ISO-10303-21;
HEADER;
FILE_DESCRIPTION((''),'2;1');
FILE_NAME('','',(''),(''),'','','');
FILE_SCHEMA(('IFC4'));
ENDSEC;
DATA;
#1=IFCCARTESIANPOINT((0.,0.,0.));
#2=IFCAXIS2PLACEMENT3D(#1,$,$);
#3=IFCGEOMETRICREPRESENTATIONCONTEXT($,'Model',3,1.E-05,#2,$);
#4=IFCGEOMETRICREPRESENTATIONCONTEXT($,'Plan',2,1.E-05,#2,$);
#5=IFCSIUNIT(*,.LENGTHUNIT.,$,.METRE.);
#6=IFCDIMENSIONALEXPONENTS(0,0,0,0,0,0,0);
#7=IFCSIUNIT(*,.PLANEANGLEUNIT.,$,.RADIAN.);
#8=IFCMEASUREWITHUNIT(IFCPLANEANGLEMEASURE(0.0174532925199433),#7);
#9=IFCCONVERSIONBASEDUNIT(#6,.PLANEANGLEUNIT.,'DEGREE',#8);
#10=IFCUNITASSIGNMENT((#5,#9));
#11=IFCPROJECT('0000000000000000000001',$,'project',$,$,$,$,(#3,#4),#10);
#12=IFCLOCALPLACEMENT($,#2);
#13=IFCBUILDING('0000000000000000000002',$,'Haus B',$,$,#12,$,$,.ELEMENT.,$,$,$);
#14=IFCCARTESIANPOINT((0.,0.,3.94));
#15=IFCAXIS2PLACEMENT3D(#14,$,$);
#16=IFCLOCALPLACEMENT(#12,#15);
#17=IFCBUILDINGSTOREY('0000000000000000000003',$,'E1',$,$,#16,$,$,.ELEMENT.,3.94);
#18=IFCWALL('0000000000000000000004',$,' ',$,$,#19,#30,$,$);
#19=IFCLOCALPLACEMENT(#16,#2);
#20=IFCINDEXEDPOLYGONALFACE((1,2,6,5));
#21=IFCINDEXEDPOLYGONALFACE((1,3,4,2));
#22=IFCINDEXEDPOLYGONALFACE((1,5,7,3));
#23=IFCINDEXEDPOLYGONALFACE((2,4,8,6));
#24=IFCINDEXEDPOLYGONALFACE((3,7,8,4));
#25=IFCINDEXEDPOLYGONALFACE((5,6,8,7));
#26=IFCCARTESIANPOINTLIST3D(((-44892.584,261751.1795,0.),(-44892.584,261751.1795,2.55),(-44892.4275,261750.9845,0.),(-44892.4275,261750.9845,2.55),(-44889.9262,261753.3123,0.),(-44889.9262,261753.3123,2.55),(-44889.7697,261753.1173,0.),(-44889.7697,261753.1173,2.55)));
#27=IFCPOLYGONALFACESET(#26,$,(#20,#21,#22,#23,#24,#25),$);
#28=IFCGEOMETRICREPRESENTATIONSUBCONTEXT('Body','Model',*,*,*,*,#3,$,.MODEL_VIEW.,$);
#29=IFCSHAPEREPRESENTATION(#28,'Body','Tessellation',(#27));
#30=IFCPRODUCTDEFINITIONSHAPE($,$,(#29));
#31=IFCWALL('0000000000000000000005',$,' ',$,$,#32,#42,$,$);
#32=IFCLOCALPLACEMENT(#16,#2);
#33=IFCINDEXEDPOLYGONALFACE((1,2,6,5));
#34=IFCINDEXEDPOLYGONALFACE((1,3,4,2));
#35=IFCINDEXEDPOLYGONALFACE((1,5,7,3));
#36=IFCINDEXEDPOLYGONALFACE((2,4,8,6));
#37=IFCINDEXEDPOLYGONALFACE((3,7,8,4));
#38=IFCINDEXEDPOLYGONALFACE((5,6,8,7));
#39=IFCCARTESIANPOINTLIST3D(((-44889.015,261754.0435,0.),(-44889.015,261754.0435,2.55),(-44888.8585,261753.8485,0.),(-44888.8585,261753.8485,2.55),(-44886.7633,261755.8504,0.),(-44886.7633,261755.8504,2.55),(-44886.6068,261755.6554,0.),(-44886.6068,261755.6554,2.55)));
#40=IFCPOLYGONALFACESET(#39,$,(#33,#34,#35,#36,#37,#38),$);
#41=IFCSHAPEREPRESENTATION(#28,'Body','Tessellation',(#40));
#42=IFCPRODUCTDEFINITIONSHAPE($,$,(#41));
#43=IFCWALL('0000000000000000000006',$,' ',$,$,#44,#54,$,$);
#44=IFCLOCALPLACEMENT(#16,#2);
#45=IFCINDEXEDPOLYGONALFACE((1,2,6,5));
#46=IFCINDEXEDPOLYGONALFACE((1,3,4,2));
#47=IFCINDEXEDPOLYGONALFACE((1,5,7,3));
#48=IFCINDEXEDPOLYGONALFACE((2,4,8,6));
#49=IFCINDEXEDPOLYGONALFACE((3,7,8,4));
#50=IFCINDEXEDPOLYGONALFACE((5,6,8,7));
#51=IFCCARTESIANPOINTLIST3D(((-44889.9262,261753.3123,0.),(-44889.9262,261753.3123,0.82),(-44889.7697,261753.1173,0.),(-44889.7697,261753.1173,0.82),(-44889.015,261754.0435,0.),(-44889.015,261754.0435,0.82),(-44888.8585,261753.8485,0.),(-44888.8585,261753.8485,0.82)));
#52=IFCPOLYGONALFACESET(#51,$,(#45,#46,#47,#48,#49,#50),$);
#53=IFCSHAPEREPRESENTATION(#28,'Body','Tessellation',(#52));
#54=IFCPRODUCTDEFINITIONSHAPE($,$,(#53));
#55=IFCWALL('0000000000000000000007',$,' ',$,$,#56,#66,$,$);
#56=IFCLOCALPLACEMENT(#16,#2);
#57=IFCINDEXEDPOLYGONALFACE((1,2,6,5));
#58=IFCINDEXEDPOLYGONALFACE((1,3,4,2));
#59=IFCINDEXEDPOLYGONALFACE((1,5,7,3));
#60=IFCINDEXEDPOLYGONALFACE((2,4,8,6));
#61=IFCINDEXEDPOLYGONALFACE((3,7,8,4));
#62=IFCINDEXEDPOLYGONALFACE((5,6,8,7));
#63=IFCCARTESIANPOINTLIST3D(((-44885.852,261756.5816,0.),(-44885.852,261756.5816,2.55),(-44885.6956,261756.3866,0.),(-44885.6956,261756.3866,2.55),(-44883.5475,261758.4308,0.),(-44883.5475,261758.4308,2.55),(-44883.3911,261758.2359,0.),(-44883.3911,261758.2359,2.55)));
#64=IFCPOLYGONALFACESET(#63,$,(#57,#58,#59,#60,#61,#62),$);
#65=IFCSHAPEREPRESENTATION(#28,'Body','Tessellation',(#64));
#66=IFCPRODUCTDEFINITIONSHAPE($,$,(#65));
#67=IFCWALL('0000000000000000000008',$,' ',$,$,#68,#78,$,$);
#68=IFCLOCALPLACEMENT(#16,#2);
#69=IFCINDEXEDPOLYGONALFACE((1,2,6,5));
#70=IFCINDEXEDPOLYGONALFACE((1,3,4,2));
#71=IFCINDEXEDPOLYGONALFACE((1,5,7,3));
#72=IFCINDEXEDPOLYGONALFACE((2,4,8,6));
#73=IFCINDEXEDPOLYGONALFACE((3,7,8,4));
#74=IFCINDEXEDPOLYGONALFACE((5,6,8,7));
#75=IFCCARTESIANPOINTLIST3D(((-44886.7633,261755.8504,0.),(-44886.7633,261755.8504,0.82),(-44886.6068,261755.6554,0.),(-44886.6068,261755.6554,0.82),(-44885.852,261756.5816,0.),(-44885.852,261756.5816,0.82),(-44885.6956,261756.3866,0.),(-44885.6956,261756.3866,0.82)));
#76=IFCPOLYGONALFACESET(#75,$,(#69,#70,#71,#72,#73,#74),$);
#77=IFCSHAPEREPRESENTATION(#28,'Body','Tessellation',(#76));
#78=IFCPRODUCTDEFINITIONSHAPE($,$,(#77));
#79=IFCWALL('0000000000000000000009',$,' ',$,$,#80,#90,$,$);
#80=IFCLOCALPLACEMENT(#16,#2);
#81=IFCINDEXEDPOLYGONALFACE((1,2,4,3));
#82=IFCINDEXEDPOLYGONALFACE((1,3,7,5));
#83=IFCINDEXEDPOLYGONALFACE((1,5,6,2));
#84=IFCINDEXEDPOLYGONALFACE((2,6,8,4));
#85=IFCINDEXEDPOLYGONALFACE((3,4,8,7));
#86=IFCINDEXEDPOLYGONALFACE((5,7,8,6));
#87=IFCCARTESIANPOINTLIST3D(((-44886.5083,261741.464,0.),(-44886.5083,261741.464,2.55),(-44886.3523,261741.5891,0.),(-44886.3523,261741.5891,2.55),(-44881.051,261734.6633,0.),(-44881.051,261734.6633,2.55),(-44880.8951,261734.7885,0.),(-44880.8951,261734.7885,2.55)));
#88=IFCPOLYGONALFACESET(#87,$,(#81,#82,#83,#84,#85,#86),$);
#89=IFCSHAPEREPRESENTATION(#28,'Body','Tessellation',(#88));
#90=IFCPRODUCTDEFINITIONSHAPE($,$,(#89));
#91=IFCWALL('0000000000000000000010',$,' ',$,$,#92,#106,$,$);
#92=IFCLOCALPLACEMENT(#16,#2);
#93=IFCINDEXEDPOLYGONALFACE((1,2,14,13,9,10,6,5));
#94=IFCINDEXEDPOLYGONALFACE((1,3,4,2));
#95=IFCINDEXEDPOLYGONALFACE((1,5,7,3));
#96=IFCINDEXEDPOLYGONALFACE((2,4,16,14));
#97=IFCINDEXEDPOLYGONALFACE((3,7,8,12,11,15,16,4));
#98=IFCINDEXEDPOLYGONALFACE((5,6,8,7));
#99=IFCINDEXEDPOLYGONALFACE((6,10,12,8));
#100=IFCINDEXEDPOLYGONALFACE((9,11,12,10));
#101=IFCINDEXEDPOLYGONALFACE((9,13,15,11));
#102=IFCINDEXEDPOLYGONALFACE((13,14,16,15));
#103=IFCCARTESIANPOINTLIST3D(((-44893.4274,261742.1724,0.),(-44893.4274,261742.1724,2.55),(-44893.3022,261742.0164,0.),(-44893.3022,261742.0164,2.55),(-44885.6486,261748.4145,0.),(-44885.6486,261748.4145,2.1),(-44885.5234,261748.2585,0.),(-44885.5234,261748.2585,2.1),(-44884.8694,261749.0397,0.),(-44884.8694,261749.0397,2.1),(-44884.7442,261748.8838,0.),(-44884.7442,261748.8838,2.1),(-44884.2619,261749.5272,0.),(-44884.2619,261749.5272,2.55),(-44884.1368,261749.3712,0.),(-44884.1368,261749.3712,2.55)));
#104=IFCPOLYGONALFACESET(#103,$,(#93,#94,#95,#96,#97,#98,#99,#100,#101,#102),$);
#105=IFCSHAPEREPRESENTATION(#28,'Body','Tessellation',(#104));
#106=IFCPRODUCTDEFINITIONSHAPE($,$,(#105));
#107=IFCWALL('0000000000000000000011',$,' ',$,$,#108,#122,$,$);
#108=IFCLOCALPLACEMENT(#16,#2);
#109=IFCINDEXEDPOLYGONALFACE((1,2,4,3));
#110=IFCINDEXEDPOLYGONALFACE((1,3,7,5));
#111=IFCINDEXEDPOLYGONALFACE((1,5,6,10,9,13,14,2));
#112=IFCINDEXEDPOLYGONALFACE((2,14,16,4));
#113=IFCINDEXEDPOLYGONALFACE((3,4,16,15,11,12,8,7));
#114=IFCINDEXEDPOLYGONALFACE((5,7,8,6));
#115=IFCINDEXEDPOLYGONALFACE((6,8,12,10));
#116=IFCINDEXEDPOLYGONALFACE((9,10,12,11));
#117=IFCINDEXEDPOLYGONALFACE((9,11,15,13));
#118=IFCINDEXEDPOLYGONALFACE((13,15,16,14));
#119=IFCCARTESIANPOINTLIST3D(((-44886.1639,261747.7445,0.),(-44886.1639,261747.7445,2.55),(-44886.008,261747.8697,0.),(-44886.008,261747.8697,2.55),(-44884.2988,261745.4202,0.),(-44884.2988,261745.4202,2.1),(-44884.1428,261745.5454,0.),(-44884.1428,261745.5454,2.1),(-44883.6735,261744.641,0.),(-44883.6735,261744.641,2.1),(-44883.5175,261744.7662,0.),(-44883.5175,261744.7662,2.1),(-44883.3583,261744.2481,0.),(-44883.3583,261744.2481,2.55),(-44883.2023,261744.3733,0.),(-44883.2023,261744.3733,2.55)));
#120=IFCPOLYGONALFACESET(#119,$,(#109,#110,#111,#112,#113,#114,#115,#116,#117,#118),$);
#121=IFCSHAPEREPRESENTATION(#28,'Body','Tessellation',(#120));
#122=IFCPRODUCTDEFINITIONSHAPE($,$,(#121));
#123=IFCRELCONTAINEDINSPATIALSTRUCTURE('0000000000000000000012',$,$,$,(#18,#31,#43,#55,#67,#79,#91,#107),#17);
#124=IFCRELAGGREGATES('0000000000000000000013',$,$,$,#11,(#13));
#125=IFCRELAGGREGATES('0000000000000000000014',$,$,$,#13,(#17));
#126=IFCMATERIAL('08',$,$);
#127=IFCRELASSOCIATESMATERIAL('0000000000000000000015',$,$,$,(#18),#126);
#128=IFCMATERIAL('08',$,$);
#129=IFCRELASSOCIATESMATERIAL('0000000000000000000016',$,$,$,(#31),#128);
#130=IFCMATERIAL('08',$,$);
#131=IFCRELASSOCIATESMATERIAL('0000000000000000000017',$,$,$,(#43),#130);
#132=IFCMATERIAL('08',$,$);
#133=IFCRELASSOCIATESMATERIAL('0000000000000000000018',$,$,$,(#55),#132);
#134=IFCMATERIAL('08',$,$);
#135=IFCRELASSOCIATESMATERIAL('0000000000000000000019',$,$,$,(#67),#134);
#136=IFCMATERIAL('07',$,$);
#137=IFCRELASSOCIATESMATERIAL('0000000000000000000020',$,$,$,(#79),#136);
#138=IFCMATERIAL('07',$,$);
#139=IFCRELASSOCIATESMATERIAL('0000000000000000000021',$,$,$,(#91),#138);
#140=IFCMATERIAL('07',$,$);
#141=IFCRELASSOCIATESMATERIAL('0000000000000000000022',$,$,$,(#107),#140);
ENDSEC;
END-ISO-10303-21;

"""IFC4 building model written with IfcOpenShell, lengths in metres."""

from ifc_helpers import new_model, entity, si_unit, converted_unit, frame, frame_2d, origin, origin_with_axes, place, context, subcontext, project, spatial, polyline, rectangle, outline, extrude, material, element, save


model = new_model("IFC4")

# Units and contexts
model_context = context("Model", 3, precision=1e-05, world=origin())
plan_context = context("Plan", 2, precision=1e-05, world=origin())
body_context = subcontext(model_context, "Body", "Model", "MODEL_VIEW")
ifc_project = project(units=[si_unit("LENGTHUNIT", "METRE"), converted_unit("PLANEANGLEUNIT", "DEGREE", entity("IfcPlaneAngleMeasure", 0.0174532925199433), si_unit("PLANEANGLEUNIT", "RADIAN"), dimensions=[0, 0, 0, 0, 0, 0, 0])], contexts=[model_context, plan_context])

# Building, storey
building_placement = place(None, origin())
building = spatial("IfcBuilding", under=ifc_project, at=building_placement, Name="Haus B", CompositionType="ELEMENT")
storey_placement = place(building_placement, frame((0.0, 0.0, 3.94)))
storey = spatial("IfcBuildingStorey", under=building, at=storey_placement, Name="E1", CompositionType="ELEMENT", Elevation=3.94)

# Walls
ifc_material_1 = material(Name="08")
wall_1_placement = place(storey_placement, frame((-44892.4275, 261750.9845, 0.0), z_axis=(0.0, 0.0, 1.0), x_axis=(0.779935, 0.625861, 0.0)))
element("IfcWall", 1, at=wall_1_placement, inside=storey, material=ifc_material_1, Name=" ", context=body_context, shape_type="SweptSolid", body=[
    extrude(rectangle(XDim=3.4077, YDim=0.25, at=frame_2d((1.7039, 0.125), x_axis=(1.0, 0.0))), origin_with_axes(), (0.0, 0.0, 1.0), 2.55),
])
ifc_material_2 = material(Name="08")
wall_2_placement = place(storey_placement, frame((-44888.8585, 261753.8485, 0.0), z_axis=(0.0, 0.0, 1.0), x_axis=(0.779935, 0.625861, 0.0)))
element("IfcWall", 2, at=wall_2_placement, inside=storey, material=ifc_material_2, Name=" ", context=body_context, shape_type="SweptSolid", body=[
    extrude(rectangle(XDim=2.887, YDim=0.25, at=frame_2d((1.4435, 0.125), x_axis=(1.0, 0.0))), origin_with_axes(), (0.0, 0.0, 1.0), 2.55),
])
ifc_material_3 = material(Name="08")
wall_3_placement = place(storey_placement, frame((-44889.7697, 261753.1173, 0.0), z_axis=(0.0, 0.0, 1.0), x_axis=(0.779935, 0.625861, 0.0)))
element("IfcWall", 3, at=wall_3_placement, inside=storey, material=ifc_material_3, Name=" ", context=body_context, shape_type="SweptSolid", body=[
    extrude(rectangle(XDim=1.1684, YDim=0.25, at=frame_2d((0.5842, 0.125), x_axis=(1.0, 0.0))), origin_with_axes(), (0.0, 0.0, 1.0), 0.82),
])
ifc_material_4 = material(Name="08")
wall_4_placement = place(storey_placement, frame((-44885.6956, 261756.3866, 0.0), z_axis=(0.0, 0.0, 1.0), x_axis=(0.779935, 0.625861, 0.0)))
element("IfcWall", 4, at=wall_4_placement, inside=storey, material=ifc_material_4, Name=" ", context=body_context, shape_type="SweptSolid", body=[
    extrude(rectangle(XDim=2.9548, YDim=0.25, at=frame_2d((1.4774, 0.125), x_axis=(1.0, 0.0))), origin_with_axes(), (0.0, 0.0, 1.0), 2.55),
])
ifc_material_5 = material(Name="08")
wall_5_placement = place(storey_placement, frame((-44886.6068, 261755.6554, 0.0), z_axis=(0.0, 0.0, 1.0), x_axis=(0.779935, 0.625861, 0.0)))
element("IfcWall", 5, at=wall_5_placement, inside=storey, material=ifc_material_5, Name=" ", context=body_context, shape_type="SweptSolid", body=[
    extrude(rectangle(XDim=1.1684, YDim=0.25, at=frame_2d((0.5842, 0.125), x_axis=(1.0, 0.0))), origin_with_axes(), (0.0, 0.0, 1.0), 0.82),
])
ifc_material_6 = material(Name="07")
wall_6_placement = place(storey_placement, frame((-44886.5083, 261741.464, 0.0), z_axis=(0.0, 0.0, 1.0), x_axis=(0.625861, -0.779935, 0.0)))
element("IfcWall", 6, at=wall_6_placement, inside=storey, material=ifc_material_6, Name=" ", context=body_context, shape_type="SweptSolid", body=[
    extrude(rectangle(XDim=8.7195, YDim=0.2, at=frame_2d((4.3598, 0.1), x_axis=(1.0, 0.0))), origin_with_axes(), (0.0, 0.0, 1.0), 2.55),
])

# Walls, openings
ifc_material_7 = material(Name="07")
wall_7_placement = place(storey_placement, frame((-44893.3022, 261742.0164, 0.0), z_axis=(0.0, 0.0, 1.0), x_axis=(0.779935, 0.625861, 0.0)))
wall_7 = element("IfcWall", 7, at=wall_7_placement, inside=storey, material=ifc_material_7, Name=" ", context=body_context, shape_type="SweptSolid", body=[
    extrude(rectangle(XDim=11.7515, YDim=0.2, at=frame_2d((5.8758, 0.1), x_axis=(1.0, 0.0))), origin_with_axes(), (0.0, 0.0, 1.0), 2.55),
])
opening_1_placement = place(wall_7_placement, frame((9.9736, 0.0, 0.0), z_axis=(0.0, 1.0, 0.0), x_axis=(0.0, 0.0, 1.0)))
element("IfcOpeningElement", 8, at=opening_1_placement, cuts=wall_7, ObjectType="Opening", context=body_context, shape_type="SweptSolid", body=[
    extrude(outline(polyline([(0.0, 0.999), (2.1, 0.999), (2.1, 0.0), (0.0, 0.0), (0.0, 0.999)])), origin_with_axes(), (0.0, 0.0, 1.0), 0.2),
])
ifc_material_8 = material(Name="07")
wall_8_placement = place(storey_placement, frame((-44886.1639, 261747.7445, 0.0), z_axis=(0.0, 0.0, 1.0), x_axis=(0.625861, -0.779935, 0.0)))
wall_8 = element("IfcWall", 9, at=wall_8_placement, inside=storey, material=ifc_material_8, Name=" ", context=body_context, shape_type="SweptSolid", body=[
    extrude(rectangle(XDim=4.4829, YDim=0.2, at=frame_2d((2.2415, 0.1), x_axis=(1.0, 0.0))), origin_with_axes(), (0.0, 0.0, 1.0), 2.55),
])
opening_2_placement = place(wall_8_placement, frame((3.9792, 0.2, 0.0), z_axis=(0.0, -1.0, 0.0), x_axis=(0.0, 0.0, 1.0)))
element("IfcOpeningElement", 10, at=opening_2_placement, cuts=wall_8, ObjectType="Opening", context=body_context, shape_type="SweptSolid", body=[
    extrude(outline(polyline([(0.0, 0.999), (2.1, 0.999), (2.1, 0.0), (0.0, 0.0), (0.0, 0.999)])), origin_with_axes(), (0.0, 0.0, 1.0), 0.2),
])

save(model, "model.ifc")
